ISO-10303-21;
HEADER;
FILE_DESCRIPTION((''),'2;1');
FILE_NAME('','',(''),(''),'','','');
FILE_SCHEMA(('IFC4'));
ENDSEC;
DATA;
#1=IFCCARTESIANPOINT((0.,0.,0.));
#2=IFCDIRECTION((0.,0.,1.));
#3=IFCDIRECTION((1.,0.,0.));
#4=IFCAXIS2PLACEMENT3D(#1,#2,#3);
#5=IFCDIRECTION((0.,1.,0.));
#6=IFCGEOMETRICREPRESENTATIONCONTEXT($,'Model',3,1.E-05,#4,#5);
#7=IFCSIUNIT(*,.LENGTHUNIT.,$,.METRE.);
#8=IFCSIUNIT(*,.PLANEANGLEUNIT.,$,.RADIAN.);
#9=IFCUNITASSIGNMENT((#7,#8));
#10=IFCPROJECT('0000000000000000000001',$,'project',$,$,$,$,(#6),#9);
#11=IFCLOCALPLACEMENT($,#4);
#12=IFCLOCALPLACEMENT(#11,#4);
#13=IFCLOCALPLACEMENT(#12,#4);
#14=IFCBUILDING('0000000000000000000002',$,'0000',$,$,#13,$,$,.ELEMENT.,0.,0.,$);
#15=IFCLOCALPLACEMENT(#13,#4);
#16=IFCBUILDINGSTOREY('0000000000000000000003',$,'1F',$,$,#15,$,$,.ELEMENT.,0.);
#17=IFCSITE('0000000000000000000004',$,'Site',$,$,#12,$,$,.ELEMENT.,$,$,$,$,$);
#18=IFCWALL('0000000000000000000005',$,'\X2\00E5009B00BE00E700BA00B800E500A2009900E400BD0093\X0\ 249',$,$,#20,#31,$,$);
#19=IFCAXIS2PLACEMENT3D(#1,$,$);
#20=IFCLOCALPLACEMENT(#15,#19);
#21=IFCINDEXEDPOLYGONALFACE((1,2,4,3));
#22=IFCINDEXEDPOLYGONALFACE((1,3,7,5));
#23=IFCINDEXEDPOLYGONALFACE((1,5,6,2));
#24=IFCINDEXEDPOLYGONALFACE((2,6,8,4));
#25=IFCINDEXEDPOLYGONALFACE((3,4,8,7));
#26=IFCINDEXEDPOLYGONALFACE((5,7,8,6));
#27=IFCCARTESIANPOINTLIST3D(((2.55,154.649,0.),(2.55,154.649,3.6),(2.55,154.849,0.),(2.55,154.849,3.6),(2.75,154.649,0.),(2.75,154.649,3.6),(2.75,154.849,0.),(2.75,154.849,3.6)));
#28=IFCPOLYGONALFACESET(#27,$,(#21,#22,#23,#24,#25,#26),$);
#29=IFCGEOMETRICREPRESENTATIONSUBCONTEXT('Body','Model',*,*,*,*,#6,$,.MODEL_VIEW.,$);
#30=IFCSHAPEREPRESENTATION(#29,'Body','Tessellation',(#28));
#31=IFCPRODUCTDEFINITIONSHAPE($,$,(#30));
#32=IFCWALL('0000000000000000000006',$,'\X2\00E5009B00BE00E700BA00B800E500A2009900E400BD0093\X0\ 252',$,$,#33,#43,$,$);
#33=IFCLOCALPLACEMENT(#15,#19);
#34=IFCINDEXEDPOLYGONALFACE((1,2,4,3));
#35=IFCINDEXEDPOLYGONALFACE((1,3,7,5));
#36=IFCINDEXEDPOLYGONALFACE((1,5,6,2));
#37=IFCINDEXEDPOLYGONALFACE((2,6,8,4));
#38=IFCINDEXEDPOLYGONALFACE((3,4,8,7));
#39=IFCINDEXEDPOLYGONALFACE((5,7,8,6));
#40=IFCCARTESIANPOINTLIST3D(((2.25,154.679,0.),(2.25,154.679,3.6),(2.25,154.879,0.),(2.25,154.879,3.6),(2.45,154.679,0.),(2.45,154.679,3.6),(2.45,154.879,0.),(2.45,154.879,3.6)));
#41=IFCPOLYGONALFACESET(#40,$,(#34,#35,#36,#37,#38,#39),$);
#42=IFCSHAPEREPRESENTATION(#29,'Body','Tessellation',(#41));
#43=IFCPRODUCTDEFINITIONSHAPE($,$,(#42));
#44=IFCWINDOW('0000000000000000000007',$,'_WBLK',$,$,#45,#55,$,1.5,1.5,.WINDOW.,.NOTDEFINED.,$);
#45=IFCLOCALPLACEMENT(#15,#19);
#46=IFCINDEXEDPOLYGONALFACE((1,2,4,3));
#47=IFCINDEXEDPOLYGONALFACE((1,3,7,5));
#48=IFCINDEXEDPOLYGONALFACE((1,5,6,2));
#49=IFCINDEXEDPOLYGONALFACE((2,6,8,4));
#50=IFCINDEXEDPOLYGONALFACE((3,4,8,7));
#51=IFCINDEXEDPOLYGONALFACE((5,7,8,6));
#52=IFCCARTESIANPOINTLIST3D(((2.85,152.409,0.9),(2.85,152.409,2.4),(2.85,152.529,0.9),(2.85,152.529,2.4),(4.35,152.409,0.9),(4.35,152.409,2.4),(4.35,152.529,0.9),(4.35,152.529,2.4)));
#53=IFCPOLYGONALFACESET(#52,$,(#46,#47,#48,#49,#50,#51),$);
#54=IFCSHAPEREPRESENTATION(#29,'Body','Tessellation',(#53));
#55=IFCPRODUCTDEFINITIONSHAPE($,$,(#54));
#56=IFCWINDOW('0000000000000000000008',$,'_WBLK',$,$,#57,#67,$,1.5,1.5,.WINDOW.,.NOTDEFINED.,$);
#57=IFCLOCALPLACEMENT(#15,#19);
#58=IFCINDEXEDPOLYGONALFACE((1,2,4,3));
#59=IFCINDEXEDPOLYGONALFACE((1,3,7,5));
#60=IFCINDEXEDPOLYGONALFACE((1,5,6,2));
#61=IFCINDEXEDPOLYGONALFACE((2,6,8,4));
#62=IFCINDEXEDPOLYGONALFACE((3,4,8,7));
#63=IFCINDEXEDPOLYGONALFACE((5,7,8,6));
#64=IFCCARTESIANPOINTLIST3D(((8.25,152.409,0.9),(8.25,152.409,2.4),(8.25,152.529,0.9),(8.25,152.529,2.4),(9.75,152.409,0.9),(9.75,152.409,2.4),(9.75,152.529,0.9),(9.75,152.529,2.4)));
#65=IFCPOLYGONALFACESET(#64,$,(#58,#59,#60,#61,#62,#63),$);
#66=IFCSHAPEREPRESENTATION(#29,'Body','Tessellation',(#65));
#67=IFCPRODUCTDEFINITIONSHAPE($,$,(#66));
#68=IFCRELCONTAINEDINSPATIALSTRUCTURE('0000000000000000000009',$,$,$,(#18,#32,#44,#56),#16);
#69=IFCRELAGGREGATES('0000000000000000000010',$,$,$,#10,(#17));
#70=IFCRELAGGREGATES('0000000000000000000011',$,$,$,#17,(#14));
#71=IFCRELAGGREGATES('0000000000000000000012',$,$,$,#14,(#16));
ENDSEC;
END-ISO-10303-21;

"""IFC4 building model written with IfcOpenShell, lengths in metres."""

from ifc_helpers import new_model, si_unit, direction, frame, frame_2d, origin_with_axes, place, context, subcontext, project, spatial, rectangle, extrude, element, save


model = new_model("IFC4")

# Units and contexts
model_context = context("Model", 3, precision=1e-05, world=origin_with_axes(), true_north=direction((0.0, 1.0, 0.0)))
body_context = subcontext(model_context, "Body", "Model", "MODEL_VIEW")
ifc_project = project(units=[si_unit("LENGTHUNIT", "METRE"), si_unit("PLANEANGLEUNIT", "RADIAN")], contexts=[model_context])

# Site, building, storey
placement = place(None, origin_with_axes())
site_placement = place(placement, origin_with_axes())
site = spatial("IfcSite", under=ifc_project, at=site_placement, Name="Site", CompositionType="ELEMENT")
building_placement = place(site_placement, origin_with_axes())
building = spatial("IfcBuilding", under=site, at=building_placement, Name="0000", CompositionType="ELEMENT", ElevationOfRefHeight=0.0, ElevationOfTerrain=0.0)
storey_placement = place(building_placement, origin_with_axes())
storey = spatial("IfcBuildingStorey", under=building, at=storey_placement, Name="1F", CompositionType="ELEMENT", Elevation=0.0)

# Walls
for number, where, z_axis, x_axis, name in (
    (1, (2.65, 154.749, 0.0), (0.0, 0.0, 1.0), (0.0, 1.0, 0.0), "å\u009b¾çº¸å¢\u0099ä½\u0093 249"),
    (2, (2.35, 154.779, 0.0), (0.0, 0.0, 1.0), (0.0, 1.0, 0.0), "å\u009b¾çº¸å¢\u0099ä½\u0093 252"),
):
    element("IfcWall", number, at=place(storey_placement, frame(where, z_axis=z_axis, x_axis=x_axis)), inside=storey, Name=name, context=body_context, shape_type="SweptSolid", body=[
        extrude(rectangle(XDim=0.2, YDim=0.2, at=frame_2d((0.0, 0.0), x_axis=(1.0, 0.0, 0.0))), frame((0.0, 0.0, 0.0), z_axis=(0.0, 0.0, 1.0)), (0.0, 0.0, 1.0), 3.6),
    ])

# Windows
for number, where, z_axis, x_axis, name in (
    (3, (3.6, 152.469, 0.9), (0.0, 0.0, 1.0), (1.0, 0.0, 0.0), "_WBLK"),
    (4, (9.0, 152.469, 0.9), (0.0, 0.0, 1.0), (1.0, 0.0, 0.0), "_WBLK"),
):
    element("IfcWindow", number, at=place(storey_placement, frame(where, z_axis=z_axis, x_axis=x_axis)), inside=storey, Name=name, OverallHeight=1.5, OverallWidth=1.5, PartitioningType="NOTDEFINED", PredefinedType="WINDOW", context=body_context, shape_type="SweptSolid", body=[
        extrude(rectangle(XDim=1.5, YDim=0.12, at=frame_2d((0.0, 0.0), x_axis=(1.0, 0.0, 0.0))), frame((0.0, 0.0, 0.0), z_axis=(0.0, 0.0, 1.0)), (0.0, 0.0, 1.0), 1.5),
    ])

save(model, "model.ifc")
